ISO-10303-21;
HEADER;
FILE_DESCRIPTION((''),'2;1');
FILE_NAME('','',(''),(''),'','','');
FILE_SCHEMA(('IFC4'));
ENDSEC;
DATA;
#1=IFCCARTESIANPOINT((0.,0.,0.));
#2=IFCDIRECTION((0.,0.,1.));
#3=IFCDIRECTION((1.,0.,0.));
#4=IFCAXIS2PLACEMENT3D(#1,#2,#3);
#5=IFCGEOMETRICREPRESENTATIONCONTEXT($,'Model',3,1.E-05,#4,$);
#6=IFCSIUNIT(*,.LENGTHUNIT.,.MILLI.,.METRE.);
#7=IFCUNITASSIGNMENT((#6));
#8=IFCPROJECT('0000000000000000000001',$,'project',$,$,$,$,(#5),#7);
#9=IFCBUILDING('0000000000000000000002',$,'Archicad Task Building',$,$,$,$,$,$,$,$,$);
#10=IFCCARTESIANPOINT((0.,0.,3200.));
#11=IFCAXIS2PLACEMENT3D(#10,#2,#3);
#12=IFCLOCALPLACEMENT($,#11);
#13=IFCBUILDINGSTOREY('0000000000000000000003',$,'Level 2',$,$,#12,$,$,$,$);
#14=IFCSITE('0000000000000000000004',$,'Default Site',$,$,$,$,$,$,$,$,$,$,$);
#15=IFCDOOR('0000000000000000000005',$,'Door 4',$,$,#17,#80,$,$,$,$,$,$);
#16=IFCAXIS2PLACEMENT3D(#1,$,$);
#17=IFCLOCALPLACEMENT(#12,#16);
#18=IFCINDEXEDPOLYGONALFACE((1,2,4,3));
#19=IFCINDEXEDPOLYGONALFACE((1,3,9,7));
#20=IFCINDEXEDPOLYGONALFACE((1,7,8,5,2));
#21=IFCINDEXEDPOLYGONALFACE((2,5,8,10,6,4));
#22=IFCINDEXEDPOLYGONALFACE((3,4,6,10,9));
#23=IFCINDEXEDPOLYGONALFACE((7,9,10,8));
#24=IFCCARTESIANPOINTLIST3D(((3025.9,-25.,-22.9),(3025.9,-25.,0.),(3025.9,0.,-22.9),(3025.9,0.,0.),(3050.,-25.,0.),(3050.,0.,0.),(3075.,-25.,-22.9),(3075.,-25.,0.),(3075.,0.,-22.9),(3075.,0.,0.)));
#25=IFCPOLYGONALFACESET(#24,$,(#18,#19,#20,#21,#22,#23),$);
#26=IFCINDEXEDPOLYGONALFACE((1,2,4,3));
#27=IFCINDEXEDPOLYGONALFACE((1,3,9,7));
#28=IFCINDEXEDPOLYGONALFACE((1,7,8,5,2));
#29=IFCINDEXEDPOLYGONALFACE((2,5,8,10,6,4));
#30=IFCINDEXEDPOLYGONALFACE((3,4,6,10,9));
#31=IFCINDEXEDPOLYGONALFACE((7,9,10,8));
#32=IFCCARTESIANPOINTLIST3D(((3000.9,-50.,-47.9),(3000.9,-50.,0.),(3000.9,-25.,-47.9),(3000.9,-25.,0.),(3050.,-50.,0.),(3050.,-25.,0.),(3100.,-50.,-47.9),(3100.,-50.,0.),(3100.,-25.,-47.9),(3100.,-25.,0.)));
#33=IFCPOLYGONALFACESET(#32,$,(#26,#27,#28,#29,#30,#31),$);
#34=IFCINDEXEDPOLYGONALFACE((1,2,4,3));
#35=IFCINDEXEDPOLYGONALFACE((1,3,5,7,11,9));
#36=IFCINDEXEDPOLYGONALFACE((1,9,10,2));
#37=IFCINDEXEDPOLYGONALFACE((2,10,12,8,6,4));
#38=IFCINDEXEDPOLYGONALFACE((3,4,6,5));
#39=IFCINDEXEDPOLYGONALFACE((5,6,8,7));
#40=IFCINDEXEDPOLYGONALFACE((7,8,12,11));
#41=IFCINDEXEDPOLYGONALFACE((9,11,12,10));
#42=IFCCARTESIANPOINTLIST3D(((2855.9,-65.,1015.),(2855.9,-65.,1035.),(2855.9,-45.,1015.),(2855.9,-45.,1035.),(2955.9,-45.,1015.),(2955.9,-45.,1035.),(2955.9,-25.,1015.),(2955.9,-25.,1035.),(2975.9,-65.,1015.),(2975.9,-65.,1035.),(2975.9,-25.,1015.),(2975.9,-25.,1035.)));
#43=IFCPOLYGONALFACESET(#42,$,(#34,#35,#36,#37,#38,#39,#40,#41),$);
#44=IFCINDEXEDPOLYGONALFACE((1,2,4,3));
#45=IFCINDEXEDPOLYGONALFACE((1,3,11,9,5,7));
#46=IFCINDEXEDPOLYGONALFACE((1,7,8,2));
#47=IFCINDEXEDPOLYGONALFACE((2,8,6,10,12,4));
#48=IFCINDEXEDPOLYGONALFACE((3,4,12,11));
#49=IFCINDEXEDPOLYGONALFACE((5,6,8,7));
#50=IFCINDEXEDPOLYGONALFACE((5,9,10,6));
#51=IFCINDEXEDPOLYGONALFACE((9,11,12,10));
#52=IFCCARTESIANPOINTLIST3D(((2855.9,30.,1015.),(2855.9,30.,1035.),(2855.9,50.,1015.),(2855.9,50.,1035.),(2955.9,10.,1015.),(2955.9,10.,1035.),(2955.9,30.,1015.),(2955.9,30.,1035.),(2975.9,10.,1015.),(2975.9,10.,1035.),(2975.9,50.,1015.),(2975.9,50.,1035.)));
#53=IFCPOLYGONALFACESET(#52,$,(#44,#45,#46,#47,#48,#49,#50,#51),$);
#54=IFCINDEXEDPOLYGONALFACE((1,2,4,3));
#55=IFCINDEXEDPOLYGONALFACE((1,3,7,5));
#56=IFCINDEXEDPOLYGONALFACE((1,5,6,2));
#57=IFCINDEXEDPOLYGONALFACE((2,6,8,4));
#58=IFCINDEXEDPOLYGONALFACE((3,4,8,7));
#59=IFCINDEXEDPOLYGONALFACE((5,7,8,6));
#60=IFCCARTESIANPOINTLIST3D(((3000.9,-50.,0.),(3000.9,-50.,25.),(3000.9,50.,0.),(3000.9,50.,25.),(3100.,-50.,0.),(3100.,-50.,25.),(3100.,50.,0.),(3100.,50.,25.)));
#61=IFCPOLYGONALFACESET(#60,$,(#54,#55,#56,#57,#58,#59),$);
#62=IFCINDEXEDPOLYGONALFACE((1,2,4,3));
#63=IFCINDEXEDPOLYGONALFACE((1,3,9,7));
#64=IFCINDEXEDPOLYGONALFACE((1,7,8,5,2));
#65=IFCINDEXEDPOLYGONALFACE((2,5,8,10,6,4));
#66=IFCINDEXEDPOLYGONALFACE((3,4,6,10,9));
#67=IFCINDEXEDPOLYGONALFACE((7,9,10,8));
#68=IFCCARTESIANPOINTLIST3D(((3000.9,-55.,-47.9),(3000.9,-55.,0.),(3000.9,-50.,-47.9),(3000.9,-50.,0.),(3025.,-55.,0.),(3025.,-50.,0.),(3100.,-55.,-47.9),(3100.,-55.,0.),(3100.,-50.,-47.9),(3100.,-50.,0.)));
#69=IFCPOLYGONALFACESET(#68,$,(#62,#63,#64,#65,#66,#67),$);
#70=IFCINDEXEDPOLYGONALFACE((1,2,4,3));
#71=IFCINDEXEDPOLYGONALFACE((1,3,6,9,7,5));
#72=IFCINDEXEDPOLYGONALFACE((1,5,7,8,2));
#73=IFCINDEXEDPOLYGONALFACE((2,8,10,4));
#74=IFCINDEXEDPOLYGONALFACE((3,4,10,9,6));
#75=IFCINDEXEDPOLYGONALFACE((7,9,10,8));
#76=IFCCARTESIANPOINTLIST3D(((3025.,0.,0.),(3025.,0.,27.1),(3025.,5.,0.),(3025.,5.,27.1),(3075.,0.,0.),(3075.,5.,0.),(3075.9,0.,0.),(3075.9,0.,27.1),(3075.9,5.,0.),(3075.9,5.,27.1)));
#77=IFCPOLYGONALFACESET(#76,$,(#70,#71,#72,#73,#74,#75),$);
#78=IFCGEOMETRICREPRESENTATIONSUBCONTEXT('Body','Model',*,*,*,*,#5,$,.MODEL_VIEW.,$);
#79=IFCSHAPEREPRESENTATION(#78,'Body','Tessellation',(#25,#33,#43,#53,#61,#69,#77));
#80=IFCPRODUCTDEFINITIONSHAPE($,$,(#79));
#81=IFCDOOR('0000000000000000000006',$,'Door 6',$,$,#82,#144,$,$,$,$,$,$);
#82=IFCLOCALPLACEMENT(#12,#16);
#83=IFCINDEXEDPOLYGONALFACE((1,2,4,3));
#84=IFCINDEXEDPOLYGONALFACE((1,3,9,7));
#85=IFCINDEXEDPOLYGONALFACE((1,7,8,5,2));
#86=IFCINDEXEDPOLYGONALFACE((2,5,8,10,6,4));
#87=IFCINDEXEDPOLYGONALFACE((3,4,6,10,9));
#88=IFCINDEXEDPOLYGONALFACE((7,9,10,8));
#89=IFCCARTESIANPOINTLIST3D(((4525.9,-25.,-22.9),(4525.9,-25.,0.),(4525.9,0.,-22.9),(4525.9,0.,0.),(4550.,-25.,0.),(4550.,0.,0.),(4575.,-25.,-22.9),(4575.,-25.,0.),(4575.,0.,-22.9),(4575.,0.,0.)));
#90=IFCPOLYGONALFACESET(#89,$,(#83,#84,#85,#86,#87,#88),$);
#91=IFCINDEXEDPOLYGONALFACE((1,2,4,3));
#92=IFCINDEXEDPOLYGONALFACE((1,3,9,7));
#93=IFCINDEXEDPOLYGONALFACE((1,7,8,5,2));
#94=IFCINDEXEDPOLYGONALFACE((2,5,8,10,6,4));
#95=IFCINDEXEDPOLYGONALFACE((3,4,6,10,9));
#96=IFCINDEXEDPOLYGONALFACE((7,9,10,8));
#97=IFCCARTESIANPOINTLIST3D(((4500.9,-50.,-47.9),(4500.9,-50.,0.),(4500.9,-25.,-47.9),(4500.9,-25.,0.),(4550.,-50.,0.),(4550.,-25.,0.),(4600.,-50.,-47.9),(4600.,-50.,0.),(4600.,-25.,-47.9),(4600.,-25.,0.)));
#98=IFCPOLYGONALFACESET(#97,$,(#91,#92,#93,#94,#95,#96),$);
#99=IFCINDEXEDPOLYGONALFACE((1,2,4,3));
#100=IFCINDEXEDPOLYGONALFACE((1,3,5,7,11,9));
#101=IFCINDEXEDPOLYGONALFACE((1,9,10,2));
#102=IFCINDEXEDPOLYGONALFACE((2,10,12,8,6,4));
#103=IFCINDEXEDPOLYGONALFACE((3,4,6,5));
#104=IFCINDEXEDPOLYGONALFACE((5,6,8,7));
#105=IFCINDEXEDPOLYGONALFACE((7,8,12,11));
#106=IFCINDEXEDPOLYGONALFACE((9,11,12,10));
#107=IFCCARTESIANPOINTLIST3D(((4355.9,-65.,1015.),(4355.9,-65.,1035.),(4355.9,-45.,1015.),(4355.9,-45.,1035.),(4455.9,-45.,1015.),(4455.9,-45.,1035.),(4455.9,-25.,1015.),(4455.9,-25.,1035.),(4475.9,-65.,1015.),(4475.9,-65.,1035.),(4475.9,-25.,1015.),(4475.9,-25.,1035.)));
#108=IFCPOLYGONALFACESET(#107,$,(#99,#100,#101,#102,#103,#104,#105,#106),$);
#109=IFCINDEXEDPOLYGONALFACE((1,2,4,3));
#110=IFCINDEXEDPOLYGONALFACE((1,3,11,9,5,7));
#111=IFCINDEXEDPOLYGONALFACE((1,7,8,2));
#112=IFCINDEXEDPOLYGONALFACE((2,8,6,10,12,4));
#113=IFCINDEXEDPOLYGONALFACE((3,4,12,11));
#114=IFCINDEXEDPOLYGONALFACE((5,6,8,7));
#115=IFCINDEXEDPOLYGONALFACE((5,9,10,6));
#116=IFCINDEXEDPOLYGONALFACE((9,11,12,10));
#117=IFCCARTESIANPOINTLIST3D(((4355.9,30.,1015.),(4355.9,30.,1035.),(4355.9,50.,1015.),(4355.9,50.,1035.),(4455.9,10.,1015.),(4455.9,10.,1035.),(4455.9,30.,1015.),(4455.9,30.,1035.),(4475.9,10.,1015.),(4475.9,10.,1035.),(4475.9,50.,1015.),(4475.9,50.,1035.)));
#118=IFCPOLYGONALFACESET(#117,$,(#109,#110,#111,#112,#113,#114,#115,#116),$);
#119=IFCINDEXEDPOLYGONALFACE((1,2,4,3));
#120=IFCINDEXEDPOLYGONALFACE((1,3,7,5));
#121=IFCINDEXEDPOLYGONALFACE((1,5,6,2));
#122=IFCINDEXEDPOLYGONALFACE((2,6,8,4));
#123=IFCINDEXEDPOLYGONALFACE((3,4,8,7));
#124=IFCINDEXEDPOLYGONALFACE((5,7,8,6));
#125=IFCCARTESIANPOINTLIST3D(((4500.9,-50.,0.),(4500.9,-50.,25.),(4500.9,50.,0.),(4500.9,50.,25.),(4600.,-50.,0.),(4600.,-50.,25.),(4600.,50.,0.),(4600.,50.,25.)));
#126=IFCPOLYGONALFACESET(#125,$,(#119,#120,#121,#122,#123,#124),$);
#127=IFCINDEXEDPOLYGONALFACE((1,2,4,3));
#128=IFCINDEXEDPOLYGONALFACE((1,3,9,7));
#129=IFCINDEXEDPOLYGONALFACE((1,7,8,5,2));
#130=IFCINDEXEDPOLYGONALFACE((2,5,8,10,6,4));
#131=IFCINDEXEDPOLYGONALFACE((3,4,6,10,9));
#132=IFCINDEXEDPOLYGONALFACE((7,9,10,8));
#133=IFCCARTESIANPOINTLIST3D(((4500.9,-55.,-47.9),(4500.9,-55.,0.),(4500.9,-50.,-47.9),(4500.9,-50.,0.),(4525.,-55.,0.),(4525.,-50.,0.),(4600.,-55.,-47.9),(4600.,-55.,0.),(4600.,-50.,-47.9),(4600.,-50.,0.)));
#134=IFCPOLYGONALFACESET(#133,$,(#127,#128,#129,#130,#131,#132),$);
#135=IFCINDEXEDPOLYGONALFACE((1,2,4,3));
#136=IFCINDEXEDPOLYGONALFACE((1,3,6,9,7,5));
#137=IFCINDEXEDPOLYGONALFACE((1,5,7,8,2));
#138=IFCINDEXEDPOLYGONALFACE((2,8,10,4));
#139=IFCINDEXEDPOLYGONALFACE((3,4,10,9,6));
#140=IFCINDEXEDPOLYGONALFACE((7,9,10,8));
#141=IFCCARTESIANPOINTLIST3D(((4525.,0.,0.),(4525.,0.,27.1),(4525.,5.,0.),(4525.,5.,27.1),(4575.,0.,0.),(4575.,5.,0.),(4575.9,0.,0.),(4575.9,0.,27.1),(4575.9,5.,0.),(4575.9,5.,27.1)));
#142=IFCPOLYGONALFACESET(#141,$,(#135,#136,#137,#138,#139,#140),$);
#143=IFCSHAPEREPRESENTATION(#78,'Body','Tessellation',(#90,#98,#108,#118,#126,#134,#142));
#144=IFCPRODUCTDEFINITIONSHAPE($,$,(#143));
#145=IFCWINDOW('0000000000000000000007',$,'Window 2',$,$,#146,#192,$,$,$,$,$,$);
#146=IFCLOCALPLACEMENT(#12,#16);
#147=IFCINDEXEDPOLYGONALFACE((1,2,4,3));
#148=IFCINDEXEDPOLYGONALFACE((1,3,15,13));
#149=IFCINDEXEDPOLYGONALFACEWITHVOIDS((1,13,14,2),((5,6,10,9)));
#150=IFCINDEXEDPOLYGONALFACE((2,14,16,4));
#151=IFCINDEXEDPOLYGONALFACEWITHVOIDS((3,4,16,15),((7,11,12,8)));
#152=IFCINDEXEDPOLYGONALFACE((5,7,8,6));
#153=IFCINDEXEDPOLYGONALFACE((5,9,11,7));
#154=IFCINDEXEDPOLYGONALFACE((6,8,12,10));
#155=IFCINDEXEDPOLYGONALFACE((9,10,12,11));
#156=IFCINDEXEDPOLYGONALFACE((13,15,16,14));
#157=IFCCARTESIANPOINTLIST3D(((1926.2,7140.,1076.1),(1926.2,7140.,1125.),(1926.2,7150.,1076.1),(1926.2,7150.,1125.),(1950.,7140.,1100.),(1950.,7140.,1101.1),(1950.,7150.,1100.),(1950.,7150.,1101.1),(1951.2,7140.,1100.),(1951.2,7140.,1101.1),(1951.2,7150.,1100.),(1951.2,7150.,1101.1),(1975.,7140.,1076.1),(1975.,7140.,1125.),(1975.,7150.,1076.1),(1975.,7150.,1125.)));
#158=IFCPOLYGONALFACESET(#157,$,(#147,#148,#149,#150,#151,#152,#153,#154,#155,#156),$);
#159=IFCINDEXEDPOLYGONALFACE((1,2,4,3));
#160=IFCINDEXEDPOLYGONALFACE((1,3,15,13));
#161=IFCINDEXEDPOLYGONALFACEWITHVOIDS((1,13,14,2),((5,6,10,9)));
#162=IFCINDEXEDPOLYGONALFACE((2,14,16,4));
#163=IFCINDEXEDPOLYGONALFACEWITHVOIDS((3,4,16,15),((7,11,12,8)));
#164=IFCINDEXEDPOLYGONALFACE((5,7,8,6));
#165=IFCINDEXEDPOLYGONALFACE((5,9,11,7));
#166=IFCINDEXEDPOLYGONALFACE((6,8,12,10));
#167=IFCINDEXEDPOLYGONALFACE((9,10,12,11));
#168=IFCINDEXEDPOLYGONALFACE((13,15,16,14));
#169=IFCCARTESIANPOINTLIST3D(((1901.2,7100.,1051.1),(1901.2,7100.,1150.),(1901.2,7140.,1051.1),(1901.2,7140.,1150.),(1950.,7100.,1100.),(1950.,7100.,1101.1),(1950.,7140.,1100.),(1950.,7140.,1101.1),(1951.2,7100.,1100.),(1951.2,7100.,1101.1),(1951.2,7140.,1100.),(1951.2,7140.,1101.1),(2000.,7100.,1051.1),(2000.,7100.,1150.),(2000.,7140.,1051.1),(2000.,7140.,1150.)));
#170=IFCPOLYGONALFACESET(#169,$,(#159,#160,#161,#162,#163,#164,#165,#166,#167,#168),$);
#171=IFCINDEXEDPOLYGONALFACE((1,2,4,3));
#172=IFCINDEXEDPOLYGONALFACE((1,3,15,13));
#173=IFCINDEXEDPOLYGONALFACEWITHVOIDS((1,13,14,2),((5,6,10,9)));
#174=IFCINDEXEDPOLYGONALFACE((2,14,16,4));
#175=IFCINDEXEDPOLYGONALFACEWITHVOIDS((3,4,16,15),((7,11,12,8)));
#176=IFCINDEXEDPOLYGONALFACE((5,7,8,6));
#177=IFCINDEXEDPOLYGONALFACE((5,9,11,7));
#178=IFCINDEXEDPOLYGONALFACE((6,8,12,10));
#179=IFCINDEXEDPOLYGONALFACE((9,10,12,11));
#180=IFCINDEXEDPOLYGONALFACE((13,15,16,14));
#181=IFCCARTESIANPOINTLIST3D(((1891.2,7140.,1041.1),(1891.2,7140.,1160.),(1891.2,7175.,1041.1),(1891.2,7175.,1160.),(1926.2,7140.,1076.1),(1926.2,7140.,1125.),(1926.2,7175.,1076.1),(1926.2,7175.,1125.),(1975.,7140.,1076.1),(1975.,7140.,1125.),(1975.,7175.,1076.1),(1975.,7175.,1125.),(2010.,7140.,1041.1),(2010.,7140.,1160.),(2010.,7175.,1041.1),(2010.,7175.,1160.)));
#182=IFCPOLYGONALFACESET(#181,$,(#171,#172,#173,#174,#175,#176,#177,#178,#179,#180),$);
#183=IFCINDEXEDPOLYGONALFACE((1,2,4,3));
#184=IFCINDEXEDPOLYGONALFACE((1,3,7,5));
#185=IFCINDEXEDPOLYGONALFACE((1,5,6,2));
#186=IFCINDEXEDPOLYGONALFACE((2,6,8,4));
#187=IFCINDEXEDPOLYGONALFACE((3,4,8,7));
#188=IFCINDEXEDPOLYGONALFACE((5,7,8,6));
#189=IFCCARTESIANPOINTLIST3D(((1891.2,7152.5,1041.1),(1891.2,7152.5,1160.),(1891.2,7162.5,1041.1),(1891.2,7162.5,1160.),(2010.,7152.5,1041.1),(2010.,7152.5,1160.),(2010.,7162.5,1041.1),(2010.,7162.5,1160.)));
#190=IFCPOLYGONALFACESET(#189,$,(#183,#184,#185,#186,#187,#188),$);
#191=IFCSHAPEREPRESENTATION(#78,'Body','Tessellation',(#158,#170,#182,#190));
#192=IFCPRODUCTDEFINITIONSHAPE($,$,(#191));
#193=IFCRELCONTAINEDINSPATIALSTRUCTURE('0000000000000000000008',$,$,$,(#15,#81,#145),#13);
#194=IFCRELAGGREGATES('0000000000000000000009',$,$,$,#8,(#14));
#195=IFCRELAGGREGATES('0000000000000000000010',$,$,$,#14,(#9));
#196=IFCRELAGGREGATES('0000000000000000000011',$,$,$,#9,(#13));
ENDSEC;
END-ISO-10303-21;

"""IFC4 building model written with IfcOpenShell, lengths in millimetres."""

from ifc_helpers import new_model, si_unit, frame, origin_with_axes, place, context, subcontext, project, spatial, line, indexed_curve, outline, extrude, element, save


model = new_model("IFC4")

# Units and contexts
model_context = context("Model", 3, precision=1e-05, world=origin_with_axes())
body_context = subcontext(model_context, "Body", "Model", "MODEL_VIEW")
ifc_project = project(units=[si_unit("LENGTHUNIT", "METRE", prefix="MILLI")], contexts=[model_context])

# Site, building, storey
site = spatial("IfcSite", under=ifc_project, Name="Default Site")
building = spatial("IfcBuilding", under=site, Name="Archicad Task Building")
storey_placement = place(None, frame((0.0, 0.0, 3200.0), z_axis=(0.0, 0.0, 1.0), x_axis=(1.0, 0.0, 0.0)))
storey = spatial("IfcBuildingStorey", under=building, at=storey_placement, Name="Level 2")

# Doors
door_1_placement = place(storey_placement, frame((3050.0, -50.0, 0.0), z_axis=(0.0, 0.0, 1.0), x_axis=(1.0, 0.0, 0.0)))
element("IfcDoor", 1, at=door_1_placement, inside=storey, Name="Door 4", context=body_context, shape_type="SweptSolid", body=[
    extrude(outline(indexed_curve([(0.0, 0.0), (0.0, 2.1), (0.9, 2.1), (0.9, 0.0), (-24.1, 0.0), (-24.1, -22.9), (25.0, -22.9), (25.0, 0.0)], segments=[line(1, 2, 3, 4, 5, 6, 7, 8, 1)])), frame((0.0, 25.0, 0.0), z_axis=(0.0, -1.0, 0.0), x_axis=(1.0, 0.0, 0.0)), (0.0, 0.0, -1.0), 25.0),
    extrude(outline(indexed_curve([(0.0, 0.0), (0.0, 2.1), (0.9, 2.1), (0.9, 0.0), (-49.1, 0.0), (-49.1, -47.9), (50.0, -47.9), (50.0, 0.0)], segments=[line(1, 2, 3, 4, 5, 6, 7, 8, 1)])), frame((0.0, 0.0, 0.0), z_axis=(0.0, -1.0, 0.0), x_axis=(1.0, 0.0, 0.0)), (0.0, 0.0, -1.0), 25.0),
    extrude(outline(indexed_curve([(0.0, 0.0), (-49.1, 0.0), (-49.1, 35.0), (0.0, 35.0)], segments=[line(1, 2, 3, 4, 1)])), frame((25.0, 25.0, 25.0), z_axis=(0.0, 0.0, 1.0), x_axis=(1.0, 0.0, 0.0)), (0.0, 0.0, 1.0), -47.9),
    extrude(outline(indexed_curve([(0.0, 0.0), (0.0, -40.0), (-120.0, -40.0), (-120.0, -20.0), (-20.0, -20.0), (-20.0, 0.0)], segments=[line(1, 2, 3, 4, 5, 6, 1)])), frame((-74.1, 25.0, 1015.0), z_axis=(0.0, 0.0, 1.0), x_axis=(1.0, 0.0, 0.0)), (0.0, 0.0, 1.0), 20.0),
    extrude(outline(indexed_curve([(0.0, 0.0), (0.0, 40.0), (-120.0, 40.0), (-120.0, 20.0), (-20.0, 20.0), (-20.0, 0.0)], segments=[line(1, 2, 3, 4, 5, 6, 1)])), frame((-74.1, 60.0, 1015.0), z_axis=(0.0, 0.0, 1.0), x_axis=(1.0, 0.0, 0.0)), (0.0, 0.0, 1.0), 20.0),
    extrude(outline(indexed_curve([(0.0, 0.0), (-99.1, 0.0), (-99.1, 100.0), (0.0, 100.0)], segments=[line(1, 2, 3, 4, 1)])), frame((50.0, 0.0, 0.0), z_axis=(0.0, 0.0, 1.0), x_axis=(1.0, 0.0, 0.0)), (0.0, 0.0, 1.0), 25.0),
    extrude(outline(indexed_curve([(0.0, 0.0), (0.0, 27.1), (50.9, 27.1), (50.9, 0.0), (-24.1, 0.0), (-24.1, -47.9), (75.0, -47.9), (75.0, 0.0)], segments=[line(1, 2, 3, 4, 5, 6, 7, 8, 1)])), frame((-25.0, -5.0, 0.0), z_axis=(0.0, -1.0, 0.0), x_axis=(1.0, 0.0, 0.0)), (0.0, 0.0, -1.0), 5.0),
    extrude(outline(indexed_curve([(0.0, 0.0), (0.0, 27.1), (50.9, 27.1), (50.9, 0.0), (0.9, 0.0), (0.9, -22.9), (50.0, -22.9), (50.0, 0.0)], segments=[line(1, 2, 3, 4, 5, 6, 7, 8, 1)])), frame((-25.0, 50.0, 0.0), z_axis=(0.0, -1.0, 0.0), x_axis=(1.0, 0.0, 0.0)), (0.0, 0.0, -1.0), 5.0),
])
door_2_placement = place(storey_placement, frame((4550.0, -50.0, 0.0), z_axis=(0.0, 0.0, 1.0), x_axis=(1.0, 0.0, 0.0)))
element("IfcDoor", 2, at=door_2_placement, inside=storey, Name="Door 6", context=body_context, shape_type="SweptSolid", body=[
    extrude(outline(indexed_curve([(0.0, 0.0), (0.0, 2.1), (0.9, 2.1), (0.9, 0.0), (-24.1, 0.0), (-24.1, -22.9), (25.0, -22.9), (25.0, 0.0)], segments=[line(1, 2, 3, 4, 5, 6, 7, 8, 1)])), frame((0.0, 25.0, 0.0), z_axis=(0.0, -1.0, 0.0), x_axis=(1.0, 0.0, 0.0)), (0.0, 0.0, -1.0), 25.0),
    extrude(outline(indexed_curve([(0.0, 0.0), (0.0, 2.1), (0.9, 2.1), (0.9, 0.0), (-49.1, 0.0), (-49.1, -47.9), (50.0, -47.9), (50.0, 0.0)], segments=[line(1, 2, 3, 4, 5, 6, 7, 8, 1)])), frame((0.0, 0.0, 0.0), z_axis=(0.0, -1.0, 0.0), x_axis=(1.0, 0.0, 0.0)), (0.0, 0.0, -1.0), 25.0),
    extrude(outline(indexed_curve([(0.0, 0.0), (-49.1, 0.0), (-49.1, 35.0), (0.0, 35.0)], segments=[line(1, 2, 3, 4, 1)])), frame((25.0, 25.0, 25.0), z_axis=(0.0, 0.0, 1.0), x_axis=(1.0, 0.0, 0.0)), (0.0, 0.0, 1.0), -47.9),
    extrude(outline(indexed_curve([(0.0, 0.0), (0.0, -40.0), (-120.0, -40.0), (-120.0, -20.0), (-20.0, -20.0), (-20.0, 0.0)], segments=[line(1, 2, 3, 4, 5, 6, 1)])), frame((-74.1, 25.0, 1015.0), z_axis=(0.0, 0.0, 1.0), x_axis=(1.0, 0.0, 0.0)), (0.0, 0.0, 1.0), 20.0),
    extrude(outline(indexed_curve([(0.0, 0.0), (0.0, 40.0), (-120.0, 40.0), (-120.0, 20.0), (-20.0, 20.0), (-20.0, 0.0)], segments=[line(1, 2, 3, 4, 5, 6, 1)])), frame((-74.1, 60.0, 1015.0), z_axis=(0.0, 0.0, 1.0), x_axis=(1.0, 0.0, 0.0)), (0.0, 0.0, 1.0), 20.0),
    extrude(outline(indexed_curve([(0.0, 0.0), (-99.1, 0.0), (-99.1, 100.0), (0.0, 100.0)], segments=[line(1, 2, 3, 4, 1)])), frame((50.0, 0.0, 0.0), z_axis=(0.0, 0.0, 1.0), x_axis=(1.0, 0.0, 0.0)), (0.0, 0.0, 1.0), 25.0),
    extrude(outline(indexed_curve([(0.0, 0.0), (0.0, 27.1), (50.9, 27.1), (50.9, 0.0), (-24.1, 0.0), (-24.1, -47.9), (75.0, -47.9), (75.0, 0.0)], segments=[line(1, 2, 3, 4, 5, 6, 7, 8, 1)])), frame((-25.0, -5.0, 0.0), z_axis=(0.0, -1.0, 0.0), x_axis=(1.0, 0.0, 0.0)), (0.0, 0.0, -1.0), 5.0),
    extrude(outline(indexed_curve([(0.0, 0.0), (0.0, 27.1), (50.9, 27.1), (50.9, 0.0), (0.9, 0.0), (0.9, -22.9), (50.0, -22.9), (50.0, 0.0)], segments=[line(1, 2, 3, 4, 5, 6, 7, 8, 1)])), frame((-25.0, 50.0, 0.0), z_axis=(0.0, -1.0, 0.0), x_axis=(1.0, 0.0, 0.0)), (0.0, 0.0, -1.0), 5.0),
])

# Window
for number, where, z_axis, x_axis, name in (
    (3, (1950.0, 7050.0, 1100.0), (0.0, 0.0, 1.0), (1.0, 0.0, 0.0), "Window 2"),
):
    element("IfcWindow", number, at=place(storey_placement, frame(where, z_axis=z_axis, x_axis=x_axis)), inside=storey, Name=name, context=body_context, shape_type="SweptSolid", body=[
        extrude(outline(indexed_curve([(0.0, 0.0), (1.2, 0.0), (1.2, 1.1), (0.0, 1.1)], segments=[line(1, 2, 3, 4, 1)]), holes=[indexed_curve([(25.0, 25.0), (-23.8, 25.0), (-23.8, -23.9), (25.0, -23.9)], segments=[line(1, 2, 3, 4, 1)])]), frame((0.0, 90.0, 0.0), z_axis=(0.0, -1.0, 0.0), x_axis=(1.0, 0.0, 0.0)), (0.0, 0.0, -1.0), 10.0),
        extrude(outline(indexed_curve([(0.0, 0.0), (1.2, 0.0), (1.2, 1.1), (0.0, 1.1)], segments=[line(1, 2, 3, 4, 1)]), holes=[indexed_curve([(50.0, 50.0), (-48.8, 50.0), (-48.8, -48.9), (50.0, -48.9)], segments=[line(1, 2, 3, 4, 1)])]), frame((0.0, 50.0, 0.0), z_axis=(0.0, -1.0, 0.0), x_axis=(1.0, 0.0, 0.0)), (0.0, 0.0, -1.0), 40.0),
        extrude(outline(indexed_curve([(0.0, 0.0), (-48.8, 0.0), (-48.8, -48.9), (0.0, -48.9)], segments=[line(1, 2, 3, 4, 1)]), holes=[indexed_curve([(35.0, 35.0), (-83.8, 35.0), (-83.8, -83.9), (35.0, -83.9)], segments=[line(1, 2, 3, 4, 1)])]), frame((25.0, 90.0, 25.0), z_axis=(0.0, -1.0, 0.0), x_axis=(1.0, 0.0, 0.0)), (0.0, 0.0, -1.0), 35.0),
        extrude(outline(indexed_curve([(35.0, 35.0), (-83.8, 35.0), (-83.8, -83.9), (35.0, -83.9)], segments=[line(1, 2, 3, 4, 1)])), frame((25.0, 102.5, 25.0), z_axis=(0.0, -1.0, 0.0), x_axis=(1.0, 0.0, 0.0)), (0.0, 0.0, -1.0), 10.0),
    ])

save(model, "model.ifc")
